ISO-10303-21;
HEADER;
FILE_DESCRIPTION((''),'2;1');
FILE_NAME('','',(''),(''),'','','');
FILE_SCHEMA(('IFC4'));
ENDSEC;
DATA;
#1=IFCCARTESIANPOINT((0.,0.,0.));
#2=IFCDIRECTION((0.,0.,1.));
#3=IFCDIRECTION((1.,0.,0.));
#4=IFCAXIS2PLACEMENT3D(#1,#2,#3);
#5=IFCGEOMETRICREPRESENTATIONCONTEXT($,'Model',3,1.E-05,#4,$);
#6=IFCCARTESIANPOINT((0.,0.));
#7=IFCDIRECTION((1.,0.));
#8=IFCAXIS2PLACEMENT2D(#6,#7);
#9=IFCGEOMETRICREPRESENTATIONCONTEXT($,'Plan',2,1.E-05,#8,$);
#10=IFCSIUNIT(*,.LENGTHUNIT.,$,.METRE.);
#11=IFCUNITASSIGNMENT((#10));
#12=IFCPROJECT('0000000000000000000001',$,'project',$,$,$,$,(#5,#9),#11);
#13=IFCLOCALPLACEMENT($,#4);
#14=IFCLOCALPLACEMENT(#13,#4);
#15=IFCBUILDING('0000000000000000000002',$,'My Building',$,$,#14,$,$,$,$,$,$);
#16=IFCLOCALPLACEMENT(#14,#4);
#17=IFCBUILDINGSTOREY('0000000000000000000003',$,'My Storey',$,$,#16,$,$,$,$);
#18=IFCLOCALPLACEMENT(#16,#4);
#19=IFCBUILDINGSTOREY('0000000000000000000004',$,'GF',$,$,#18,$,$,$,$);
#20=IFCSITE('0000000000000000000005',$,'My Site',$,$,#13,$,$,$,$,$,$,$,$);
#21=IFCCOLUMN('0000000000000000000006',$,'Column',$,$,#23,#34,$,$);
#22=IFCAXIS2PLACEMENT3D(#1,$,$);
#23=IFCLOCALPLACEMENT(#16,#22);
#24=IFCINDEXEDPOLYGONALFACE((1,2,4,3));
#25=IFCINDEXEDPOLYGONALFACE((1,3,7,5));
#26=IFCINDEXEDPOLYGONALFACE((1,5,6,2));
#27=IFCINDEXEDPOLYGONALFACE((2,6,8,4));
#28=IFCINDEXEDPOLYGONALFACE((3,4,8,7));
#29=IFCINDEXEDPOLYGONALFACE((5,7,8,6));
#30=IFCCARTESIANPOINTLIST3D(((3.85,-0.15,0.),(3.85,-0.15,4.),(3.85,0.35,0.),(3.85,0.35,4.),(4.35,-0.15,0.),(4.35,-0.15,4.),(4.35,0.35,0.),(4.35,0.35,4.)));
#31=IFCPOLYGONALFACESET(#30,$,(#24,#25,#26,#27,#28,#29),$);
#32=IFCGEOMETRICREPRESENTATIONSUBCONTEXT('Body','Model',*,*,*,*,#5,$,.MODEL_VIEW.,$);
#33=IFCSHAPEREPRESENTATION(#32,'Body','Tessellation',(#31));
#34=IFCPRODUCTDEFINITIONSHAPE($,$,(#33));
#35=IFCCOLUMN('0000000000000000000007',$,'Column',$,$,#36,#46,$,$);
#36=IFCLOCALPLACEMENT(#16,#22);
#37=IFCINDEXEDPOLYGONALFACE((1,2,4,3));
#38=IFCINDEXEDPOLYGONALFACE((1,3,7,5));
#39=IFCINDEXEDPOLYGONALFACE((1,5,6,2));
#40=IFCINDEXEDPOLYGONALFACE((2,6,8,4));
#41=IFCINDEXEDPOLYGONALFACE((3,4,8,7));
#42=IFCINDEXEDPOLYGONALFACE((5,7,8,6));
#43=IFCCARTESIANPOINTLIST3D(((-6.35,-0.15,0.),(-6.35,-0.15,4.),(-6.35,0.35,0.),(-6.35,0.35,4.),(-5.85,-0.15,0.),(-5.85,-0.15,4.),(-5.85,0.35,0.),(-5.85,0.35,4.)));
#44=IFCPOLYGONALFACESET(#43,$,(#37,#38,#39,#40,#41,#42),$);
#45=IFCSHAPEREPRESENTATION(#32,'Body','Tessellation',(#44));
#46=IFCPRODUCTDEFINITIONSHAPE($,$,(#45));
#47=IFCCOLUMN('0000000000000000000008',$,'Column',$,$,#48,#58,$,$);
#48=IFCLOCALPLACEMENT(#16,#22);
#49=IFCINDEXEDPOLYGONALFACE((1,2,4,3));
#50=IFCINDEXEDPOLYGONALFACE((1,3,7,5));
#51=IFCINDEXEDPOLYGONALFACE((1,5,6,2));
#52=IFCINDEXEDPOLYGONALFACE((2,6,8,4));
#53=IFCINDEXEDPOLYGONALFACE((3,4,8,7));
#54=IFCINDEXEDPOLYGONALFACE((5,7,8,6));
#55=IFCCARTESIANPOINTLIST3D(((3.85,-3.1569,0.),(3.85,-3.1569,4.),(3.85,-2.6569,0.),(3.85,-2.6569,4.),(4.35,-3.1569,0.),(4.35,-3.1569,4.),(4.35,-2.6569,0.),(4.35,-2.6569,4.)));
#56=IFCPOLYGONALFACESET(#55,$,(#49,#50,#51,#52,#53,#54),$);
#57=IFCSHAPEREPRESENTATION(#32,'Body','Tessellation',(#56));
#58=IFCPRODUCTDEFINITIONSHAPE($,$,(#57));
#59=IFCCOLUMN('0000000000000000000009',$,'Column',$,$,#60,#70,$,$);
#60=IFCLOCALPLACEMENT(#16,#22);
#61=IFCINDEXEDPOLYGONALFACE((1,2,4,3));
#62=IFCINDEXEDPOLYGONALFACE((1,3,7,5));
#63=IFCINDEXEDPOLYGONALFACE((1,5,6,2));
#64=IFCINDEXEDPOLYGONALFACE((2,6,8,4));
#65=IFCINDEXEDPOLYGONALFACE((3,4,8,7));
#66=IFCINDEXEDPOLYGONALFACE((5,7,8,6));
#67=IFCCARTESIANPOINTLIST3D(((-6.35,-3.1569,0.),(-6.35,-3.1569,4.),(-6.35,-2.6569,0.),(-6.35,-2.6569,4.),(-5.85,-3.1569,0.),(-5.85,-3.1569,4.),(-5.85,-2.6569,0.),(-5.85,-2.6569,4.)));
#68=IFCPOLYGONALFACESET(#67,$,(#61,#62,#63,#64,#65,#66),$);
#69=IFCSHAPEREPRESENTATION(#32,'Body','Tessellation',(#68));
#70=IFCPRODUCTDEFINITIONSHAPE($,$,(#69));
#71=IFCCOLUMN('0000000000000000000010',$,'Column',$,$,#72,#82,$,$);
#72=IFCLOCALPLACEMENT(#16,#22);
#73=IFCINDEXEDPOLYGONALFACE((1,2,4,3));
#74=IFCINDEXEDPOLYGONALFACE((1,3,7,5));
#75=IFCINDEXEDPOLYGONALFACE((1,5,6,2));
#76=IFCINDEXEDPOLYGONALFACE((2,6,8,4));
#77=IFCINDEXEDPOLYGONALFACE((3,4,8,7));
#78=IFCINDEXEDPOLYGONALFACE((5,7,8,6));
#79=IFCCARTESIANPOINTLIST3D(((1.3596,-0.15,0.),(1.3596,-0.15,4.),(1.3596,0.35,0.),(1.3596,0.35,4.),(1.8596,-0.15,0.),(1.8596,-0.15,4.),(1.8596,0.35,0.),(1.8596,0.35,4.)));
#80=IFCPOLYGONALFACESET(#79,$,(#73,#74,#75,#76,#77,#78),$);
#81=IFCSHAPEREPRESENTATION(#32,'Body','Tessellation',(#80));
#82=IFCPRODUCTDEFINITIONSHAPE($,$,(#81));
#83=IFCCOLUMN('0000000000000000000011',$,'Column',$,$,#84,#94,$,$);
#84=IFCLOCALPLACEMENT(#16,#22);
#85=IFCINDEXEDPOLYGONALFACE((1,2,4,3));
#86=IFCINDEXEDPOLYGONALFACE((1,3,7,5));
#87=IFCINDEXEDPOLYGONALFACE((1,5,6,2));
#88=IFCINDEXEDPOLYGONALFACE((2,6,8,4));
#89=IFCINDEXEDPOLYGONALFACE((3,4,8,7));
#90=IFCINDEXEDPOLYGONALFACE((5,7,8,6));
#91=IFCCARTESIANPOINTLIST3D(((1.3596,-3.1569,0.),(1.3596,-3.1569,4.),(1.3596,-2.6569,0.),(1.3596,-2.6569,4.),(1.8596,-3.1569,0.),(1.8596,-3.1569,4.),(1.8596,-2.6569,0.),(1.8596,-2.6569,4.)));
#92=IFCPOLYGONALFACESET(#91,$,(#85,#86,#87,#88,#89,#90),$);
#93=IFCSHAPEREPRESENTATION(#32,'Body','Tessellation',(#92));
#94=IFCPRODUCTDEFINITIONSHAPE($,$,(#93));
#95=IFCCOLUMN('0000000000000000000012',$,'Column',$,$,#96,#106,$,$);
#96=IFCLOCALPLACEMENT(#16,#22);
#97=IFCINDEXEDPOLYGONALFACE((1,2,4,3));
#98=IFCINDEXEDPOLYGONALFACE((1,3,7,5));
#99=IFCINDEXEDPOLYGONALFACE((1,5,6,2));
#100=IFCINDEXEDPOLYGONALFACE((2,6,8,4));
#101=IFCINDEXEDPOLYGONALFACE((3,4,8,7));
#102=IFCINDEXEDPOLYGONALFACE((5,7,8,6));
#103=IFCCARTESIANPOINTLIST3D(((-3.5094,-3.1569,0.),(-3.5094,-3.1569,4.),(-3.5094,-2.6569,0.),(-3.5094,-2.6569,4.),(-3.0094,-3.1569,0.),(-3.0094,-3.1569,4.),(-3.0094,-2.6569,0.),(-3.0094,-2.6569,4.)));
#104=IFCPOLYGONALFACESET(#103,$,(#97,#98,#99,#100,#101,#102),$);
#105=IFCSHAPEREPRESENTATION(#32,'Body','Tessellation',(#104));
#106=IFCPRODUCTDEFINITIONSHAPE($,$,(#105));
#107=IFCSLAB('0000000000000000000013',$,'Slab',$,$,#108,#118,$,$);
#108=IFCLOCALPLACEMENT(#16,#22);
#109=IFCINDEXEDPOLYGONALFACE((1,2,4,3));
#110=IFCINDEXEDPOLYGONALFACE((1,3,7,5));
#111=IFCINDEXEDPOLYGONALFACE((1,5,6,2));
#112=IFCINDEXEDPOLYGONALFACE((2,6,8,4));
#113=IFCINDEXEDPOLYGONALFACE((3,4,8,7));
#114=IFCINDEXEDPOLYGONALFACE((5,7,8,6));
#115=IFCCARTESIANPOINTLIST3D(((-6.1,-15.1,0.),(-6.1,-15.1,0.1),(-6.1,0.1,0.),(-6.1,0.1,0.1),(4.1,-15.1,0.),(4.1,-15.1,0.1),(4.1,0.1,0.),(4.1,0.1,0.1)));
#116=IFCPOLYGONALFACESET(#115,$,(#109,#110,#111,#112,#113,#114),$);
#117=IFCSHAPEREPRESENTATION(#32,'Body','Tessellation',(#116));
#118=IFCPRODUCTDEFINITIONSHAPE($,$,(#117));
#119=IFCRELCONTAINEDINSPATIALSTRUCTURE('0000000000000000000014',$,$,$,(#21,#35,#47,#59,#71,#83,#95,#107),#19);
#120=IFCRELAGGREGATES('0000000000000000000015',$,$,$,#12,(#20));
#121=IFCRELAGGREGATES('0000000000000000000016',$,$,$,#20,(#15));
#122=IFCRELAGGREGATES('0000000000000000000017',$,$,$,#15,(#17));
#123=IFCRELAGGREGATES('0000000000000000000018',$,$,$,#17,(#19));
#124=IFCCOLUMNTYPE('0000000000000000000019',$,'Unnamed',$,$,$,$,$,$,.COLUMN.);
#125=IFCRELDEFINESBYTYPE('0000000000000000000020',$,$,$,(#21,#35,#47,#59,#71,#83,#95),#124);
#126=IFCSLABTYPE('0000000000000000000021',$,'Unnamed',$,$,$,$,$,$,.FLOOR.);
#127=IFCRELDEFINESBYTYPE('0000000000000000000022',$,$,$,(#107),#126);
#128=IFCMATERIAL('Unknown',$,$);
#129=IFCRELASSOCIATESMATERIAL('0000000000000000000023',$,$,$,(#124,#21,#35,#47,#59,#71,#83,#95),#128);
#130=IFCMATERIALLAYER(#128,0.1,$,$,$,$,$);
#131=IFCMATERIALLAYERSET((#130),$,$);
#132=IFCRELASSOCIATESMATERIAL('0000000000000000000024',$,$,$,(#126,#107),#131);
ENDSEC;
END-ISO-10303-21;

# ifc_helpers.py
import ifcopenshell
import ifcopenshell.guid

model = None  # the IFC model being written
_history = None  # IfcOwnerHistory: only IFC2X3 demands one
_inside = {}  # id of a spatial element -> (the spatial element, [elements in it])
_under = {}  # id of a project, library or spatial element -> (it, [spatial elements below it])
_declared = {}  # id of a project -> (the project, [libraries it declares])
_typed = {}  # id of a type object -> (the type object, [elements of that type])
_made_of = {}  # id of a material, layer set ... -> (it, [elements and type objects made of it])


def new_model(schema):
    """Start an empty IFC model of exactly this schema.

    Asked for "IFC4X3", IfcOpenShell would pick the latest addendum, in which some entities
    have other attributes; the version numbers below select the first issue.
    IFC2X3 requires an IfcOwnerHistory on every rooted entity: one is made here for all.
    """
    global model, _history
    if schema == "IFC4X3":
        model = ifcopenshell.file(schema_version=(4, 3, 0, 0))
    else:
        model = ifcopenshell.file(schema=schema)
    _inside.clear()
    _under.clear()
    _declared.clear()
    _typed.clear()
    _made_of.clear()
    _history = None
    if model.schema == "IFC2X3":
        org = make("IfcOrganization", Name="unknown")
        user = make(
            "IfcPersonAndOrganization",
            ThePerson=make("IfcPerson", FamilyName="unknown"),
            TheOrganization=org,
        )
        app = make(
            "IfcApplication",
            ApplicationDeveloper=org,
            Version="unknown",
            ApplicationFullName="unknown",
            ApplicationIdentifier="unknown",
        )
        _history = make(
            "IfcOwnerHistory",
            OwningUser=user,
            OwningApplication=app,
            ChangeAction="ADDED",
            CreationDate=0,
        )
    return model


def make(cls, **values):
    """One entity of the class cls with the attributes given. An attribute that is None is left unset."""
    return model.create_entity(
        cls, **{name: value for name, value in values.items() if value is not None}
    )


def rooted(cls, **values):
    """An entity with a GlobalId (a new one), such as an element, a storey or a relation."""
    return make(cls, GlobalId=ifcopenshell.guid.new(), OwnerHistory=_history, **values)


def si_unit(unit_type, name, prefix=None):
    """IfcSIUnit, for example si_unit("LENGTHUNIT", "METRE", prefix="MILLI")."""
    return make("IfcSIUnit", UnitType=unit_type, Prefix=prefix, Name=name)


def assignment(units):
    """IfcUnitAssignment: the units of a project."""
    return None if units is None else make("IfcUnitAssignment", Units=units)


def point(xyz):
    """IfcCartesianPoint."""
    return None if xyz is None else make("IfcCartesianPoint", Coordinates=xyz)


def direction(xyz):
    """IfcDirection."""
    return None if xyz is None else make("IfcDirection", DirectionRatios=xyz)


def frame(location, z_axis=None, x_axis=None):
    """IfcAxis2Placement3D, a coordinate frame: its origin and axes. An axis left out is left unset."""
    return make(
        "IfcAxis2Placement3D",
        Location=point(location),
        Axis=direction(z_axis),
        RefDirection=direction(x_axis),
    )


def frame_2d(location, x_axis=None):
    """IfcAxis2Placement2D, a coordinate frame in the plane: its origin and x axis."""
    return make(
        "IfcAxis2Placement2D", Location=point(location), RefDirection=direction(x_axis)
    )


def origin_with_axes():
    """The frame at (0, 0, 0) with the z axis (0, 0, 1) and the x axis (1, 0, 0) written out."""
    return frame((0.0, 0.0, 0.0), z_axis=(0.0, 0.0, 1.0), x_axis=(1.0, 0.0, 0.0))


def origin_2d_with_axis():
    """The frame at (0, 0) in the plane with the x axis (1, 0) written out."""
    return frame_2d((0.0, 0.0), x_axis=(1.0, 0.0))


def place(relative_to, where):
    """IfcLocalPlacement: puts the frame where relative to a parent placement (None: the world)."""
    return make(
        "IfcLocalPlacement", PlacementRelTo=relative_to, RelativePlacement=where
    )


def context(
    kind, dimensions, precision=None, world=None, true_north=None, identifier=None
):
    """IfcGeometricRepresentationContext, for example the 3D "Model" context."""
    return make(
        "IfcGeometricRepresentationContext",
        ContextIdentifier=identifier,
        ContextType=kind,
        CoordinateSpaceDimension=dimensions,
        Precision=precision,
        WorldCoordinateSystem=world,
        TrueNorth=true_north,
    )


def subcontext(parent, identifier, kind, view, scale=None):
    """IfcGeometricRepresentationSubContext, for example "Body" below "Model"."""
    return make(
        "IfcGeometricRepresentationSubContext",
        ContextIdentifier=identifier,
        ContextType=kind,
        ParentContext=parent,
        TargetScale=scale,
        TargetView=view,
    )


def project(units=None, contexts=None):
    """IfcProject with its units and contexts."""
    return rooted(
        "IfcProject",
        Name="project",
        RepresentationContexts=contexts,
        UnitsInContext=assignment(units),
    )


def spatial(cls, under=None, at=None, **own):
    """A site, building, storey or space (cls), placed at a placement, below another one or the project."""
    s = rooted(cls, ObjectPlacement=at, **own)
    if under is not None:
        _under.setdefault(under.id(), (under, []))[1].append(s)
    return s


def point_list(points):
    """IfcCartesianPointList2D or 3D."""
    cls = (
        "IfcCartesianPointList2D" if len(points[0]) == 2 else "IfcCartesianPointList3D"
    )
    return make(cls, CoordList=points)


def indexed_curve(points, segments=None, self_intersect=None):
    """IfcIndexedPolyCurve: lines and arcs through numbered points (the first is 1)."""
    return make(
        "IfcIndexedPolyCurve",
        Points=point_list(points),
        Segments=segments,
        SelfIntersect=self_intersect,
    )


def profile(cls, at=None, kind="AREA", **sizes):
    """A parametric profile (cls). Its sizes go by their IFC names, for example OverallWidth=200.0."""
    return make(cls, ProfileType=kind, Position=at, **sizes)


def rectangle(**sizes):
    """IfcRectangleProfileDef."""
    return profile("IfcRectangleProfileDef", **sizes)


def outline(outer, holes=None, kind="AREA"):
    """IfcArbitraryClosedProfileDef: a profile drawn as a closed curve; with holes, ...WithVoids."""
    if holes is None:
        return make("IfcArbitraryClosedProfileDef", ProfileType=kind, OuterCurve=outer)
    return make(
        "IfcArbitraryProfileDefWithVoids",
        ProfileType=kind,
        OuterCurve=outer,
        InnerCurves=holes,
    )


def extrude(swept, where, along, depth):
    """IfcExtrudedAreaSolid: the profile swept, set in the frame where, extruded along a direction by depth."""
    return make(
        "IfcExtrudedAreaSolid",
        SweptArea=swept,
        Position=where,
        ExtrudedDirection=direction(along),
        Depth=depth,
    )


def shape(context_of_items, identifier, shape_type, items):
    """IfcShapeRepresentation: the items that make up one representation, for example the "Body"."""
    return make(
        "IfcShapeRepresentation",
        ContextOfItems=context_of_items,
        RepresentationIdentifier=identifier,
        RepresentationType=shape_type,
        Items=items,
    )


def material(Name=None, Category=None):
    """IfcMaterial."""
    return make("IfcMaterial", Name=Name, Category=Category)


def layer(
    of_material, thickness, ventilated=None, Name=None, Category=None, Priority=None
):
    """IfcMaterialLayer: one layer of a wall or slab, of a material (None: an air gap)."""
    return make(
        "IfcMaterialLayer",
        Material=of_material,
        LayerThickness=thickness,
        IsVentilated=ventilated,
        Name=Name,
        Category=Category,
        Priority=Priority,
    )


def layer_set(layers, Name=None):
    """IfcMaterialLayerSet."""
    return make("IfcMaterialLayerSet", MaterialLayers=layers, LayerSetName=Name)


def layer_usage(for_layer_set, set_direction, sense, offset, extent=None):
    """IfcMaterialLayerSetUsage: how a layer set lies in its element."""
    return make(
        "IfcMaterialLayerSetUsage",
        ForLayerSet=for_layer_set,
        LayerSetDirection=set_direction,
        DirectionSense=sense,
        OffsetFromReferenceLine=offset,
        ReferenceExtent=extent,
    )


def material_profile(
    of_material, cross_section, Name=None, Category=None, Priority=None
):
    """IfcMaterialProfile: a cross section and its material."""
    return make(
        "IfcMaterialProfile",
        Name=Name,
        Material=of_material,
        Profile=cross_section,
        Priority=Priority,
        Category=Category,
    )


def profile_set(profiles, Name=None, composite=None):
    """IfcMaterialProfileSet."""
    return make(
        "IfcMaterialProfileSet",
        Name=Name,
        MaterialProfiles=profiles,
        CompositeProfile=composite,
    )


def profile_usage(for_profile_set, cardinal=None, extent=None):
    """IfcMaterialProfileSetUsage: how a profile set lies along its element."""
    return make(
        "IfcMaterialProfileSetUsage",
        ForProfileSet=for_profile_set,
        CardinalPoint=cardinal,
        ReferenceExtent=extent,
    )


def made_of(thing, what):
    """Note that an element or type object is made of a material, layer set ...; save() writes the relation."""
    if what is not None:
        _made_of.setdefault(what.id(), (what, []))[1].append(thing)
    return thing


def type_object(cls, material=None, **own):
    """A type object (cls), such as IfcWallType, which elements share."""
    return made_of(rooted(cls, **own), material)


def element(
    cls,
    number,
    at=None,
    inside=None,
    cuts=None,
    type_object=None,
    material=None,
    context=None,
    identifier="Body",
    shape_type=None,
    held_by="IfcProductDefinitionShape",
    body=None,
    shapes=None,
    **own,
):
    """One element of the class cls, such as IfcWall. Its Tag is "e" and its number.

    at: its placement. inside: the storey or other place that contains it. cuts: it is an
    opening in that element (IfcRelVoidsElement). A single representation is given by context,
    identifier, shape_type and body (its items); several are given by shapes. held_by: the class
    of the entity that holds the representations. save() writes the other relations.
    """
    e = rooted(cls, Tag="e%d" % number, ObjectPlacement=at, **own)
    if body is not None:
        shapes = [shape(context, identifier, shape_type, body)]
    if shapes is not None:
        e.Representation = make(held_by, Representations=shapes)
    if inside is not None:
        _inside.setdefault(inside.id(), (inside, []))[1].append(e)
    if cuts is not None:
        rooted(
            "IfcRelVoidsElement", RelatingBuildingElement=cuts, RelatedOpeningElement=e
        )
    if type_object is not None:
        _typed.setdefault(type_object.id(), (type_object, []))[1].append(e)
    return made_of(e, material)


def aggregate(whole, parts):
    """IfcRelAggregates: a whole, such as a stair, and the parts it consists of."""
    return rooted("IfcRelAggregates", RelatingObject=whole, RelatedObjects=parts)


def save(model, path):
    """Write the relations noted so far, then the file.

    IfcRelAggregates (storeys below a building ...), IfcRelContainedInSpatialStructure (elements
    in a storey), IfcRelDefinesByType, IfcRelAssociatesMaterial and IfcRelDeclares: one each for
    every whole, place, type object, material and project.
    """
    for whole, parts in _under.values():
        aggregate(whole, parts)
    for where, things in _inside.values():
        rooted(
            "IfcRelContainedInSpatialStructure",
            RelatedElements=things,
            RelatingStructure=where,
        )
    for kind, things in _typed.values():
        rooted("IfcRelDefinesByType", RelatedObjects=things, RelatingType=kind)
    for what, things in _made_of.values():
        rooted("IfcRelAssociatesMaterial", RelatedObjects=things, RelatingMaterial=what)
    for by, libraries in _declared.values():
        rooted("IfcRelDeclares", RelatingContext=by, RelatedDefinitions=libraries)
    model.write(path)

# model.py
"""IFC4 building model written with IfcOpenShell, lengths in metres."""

from ifc_helpers import new_model, si_unit, frame, origin_with_axes, origin_2d_with_axis, place, context, subcontext, project, spatial, indexed_curve, rectangle, outline, extrude, material, layer, layer_set, layer_usage, material_profile, profile_set, profile_usage, type_object, element, save


model = new_model("IFC4")

# Units and contexts
model_context = context("Model", 3, precision=1e-05, world=origin_with_axes())
plan_context = context("Plan", 2, precision=1e-05, world=origin_2d_with_axis())
body_context_1 = subcontext(model_context, "Body", "Model", "MODEL_VIEW")
ifc_project = project(units=[si_unit("LENGTHUNIT", "METRE")], contexts=[model_context, plan_context])

# Site, building, storeys
site_placement = place(None, origin_with_axes())
site = spatial("IfcSite", under=ifc_project, at=site_placement, Name="My Site")
building_placement = place(site_placement, origin_with_axes())
building = spatial("IfcBuilding", under=site, at=building_placement, Name="My Building")
storey_1_placement = place(building_placement, origin_with_axes())
storey_1 = spatial("IfcBuildingStorey", under=building, at=storey_1_placement, Name="My Storey")
storey_2_placement = place(storey_1_placement, origin_with_axes())
storey_2 = spatial("IfcBuildingStorey", under=storey_1, at=storey_2_placement, Name="GF")

# Columns
ifc_material = material(Name="Unknown")
ifc_material_profile = material_profile(ifc_material, rectangle(XDim=0.5, YDim=0.5))
ifc_profile_set = profile_set([ifc_material_profile])
ifc_profile_usage_1 = profile_usage(ifc_profile_set, cardinal=5)
column_type = type_object("IfcColumnType", Name="Unnamed", PredefinedType="COLUMN", material=ifc_profile_set)
column_1_placement = place(storey_2_placement, frame((4.1, 0.1, 0.0), z_axis=(0.0, 0.0, 1.0), x_axis=(1.0, 0.0, 0.0)))
element("IfcColumn", 1, at=column_1_placement, inside=storey_2, type_object=column_type, material=ifc_profile_usage_1, Name="Column", context=body_context_1, shape_type="SweptSolid", body=[
    extrude(rectangle(XDim=0.5, YDim=0.5), origin_with_axes(), (0.0, 0.0, 1.0), 4.0),
])
ifc_profile_usage_2 = profile_usage(ifc_profile_set, cardinal=5)
column_2_placement = place(storey_2_placement, frame((-6.1, 0.1, 0.0), z_axis=(0.0, 0.0, 1.0), x_axis=(1.0, 0.0, 0.0)))
element("IfcColumn", 2, at=column_2_placement, inside=storey_2, type_object=column_type, material=ifc_profile_usage_2, Name="Column", context=body_context_1, shape_type="SweptSolid", body=[
    extrude(rectangle(XDim=0.5, YDim=0.5), origin_with_axes(), (0.0, 0.0, 1.0), 4.0),
])
ifc_profile_usage_3 = profile_usage(ifc_profile_set, cardinal=5)
column_3_placement = place(storey_2_placement, frame((4.1, -2.9069, 0.0), z_axis=(0.0, 0.0, 1.0), x_axis=(1.0, 0.0, 0.0)))
element("IfcColumn", 3, at=column_3_placement, inside=storey_2, type_object=column_type, material=ifc_profile_usage_3, Name="Column", context=body_context_1, shape_type="SweptSolid", body=[
    extrude(rectangle(XDim=0.5, YDim=0.5), origin_with_axes(), (0.0, 0.0, 1.0), 4.0),
])
ifc_profile_usage_4 = profile_usage(ifc_profile_set, cardinal=5)
column_4_placement = place(storey_2_placement, frame((-6.1, -2.9069, 0.0), z_axis=(0.0, 0.0, 1.0), x_axis=(1.0, 0.0, 0.0)))
element("IfcColumn", 4, at=column_4_placement, inside=storey_2, type_object=column_type, material=ifc_profile_usage_4, Name="Column", context=body_context_1, shape_type="SweptSolid", body=[
    extrude(rectangle(XDim=0.5, YDim=0.5), origin_with_axes(), (0.0, 0.0, 1.0), 4.0),
])
ifc_profile_usage_5 = profile_usage(ifc_profile_set, cardinal=5)
column_5_placement = place(storey_2_placement, frame((1.6096, 0.1, 0.0), z_axis=(0.0, 0.0, 1.0), x_axis=(1.0, 0.0, 0.0)))
element("IfcColumn", 5, at=column_5_placement, inside=storey_2, type_object=column_type, material=ifc_profile_usage_5, Name="Column", context=body_context_1, shape_type="SweptSolid", body=[
    extrude(rectangle(XDim=0.5, YDim=0.5), origin_with_axes(), (0.0, 0.0, 1.0), 4.0),
])
ifc_profile_usage_6 = profile_usage(ifc_profile_set, cardinal=5)
column_6_placement = place(storey_2_placement, frame((1.6096, -2.9069, 0.0), z_axis=(0.0, 0.0, 1.0), x_axis=(1.0, 0.0, 0.0)))
element("IfcColumn", 6, at=column_6_placement, inside=storey_2, type_object=column_type, material=ifc_profile_usage_6, Name="Column", context=body_context_1, shape_type="SweptSolid", body=[
    extrude(rectangle(XDim=0.5, YDim=0.5), origin_with_axes(), (0.0, 0.0, 1.0), 4.0),
])
ifc_profile_usage_7 = profile_usage(ifc_profile_set, cardinal=5)
column_7_placement = place(storey_2_placement, frame((-3.2594, -2.9069, 0.0), z_axis=(0.0, 0.0, 1.0), x_axis=(1.0, 0.0, 0.0)))
element("IfcColumn", 7, at=column_7_placement, inside=storey_2, type_object=column_type, material=ifc_profile_usage_7, Name="Column", context=body_context_1, shape_type="SweptSolid", body=[
    extrude(rectangle(XDim=0.5, YDim=0.5), origin_with_axes(), (0.0, 0.0, 1.0), 4.0),
])

# Slab
ifc_layer_1 = layer(ifc_material, 0.1)
ifc_layer_set_1 = layer_set([ifc_layer_1])
ifc_layer_usage_1 = layer_usage(ifc_layer_set_1, "AXIS3", "POSITIVE", -0.1)
slab_type = type_object("IfcSlabType", Name="Unnamed", PredefinedType="FLOOR", material=ifc_layer_set_1)
slab_placement = place(storey_2_placement, frame((-6.1, 0.1, 0.1), z_axis=(0.0, 0.0, 1.0), x_axis=(1.0, 0.0, 0.0)))
element("IfcSlab", 8, at=slab_placement, inside=storey_2, type_object=slab_type, material=ifc_layer_usage_1, Name="Slab", context=body_context_1, shape_type="SweptSolid", body=[
    extrude(outline(indexed_curve([(0.0, 0.0), (10.2, 0.0), (10.2, -15.2), (0.0, -15.2), (0.0, 0.0)])), frame((0.0, 0.0, -0.1), z_axis=(0.0, 0.0, 1.0), x_axis=(1.0, 0.0, 0.0)), (0.0, 0.0, 1.0), 0.1),
])

save(model, "model.ifc")
